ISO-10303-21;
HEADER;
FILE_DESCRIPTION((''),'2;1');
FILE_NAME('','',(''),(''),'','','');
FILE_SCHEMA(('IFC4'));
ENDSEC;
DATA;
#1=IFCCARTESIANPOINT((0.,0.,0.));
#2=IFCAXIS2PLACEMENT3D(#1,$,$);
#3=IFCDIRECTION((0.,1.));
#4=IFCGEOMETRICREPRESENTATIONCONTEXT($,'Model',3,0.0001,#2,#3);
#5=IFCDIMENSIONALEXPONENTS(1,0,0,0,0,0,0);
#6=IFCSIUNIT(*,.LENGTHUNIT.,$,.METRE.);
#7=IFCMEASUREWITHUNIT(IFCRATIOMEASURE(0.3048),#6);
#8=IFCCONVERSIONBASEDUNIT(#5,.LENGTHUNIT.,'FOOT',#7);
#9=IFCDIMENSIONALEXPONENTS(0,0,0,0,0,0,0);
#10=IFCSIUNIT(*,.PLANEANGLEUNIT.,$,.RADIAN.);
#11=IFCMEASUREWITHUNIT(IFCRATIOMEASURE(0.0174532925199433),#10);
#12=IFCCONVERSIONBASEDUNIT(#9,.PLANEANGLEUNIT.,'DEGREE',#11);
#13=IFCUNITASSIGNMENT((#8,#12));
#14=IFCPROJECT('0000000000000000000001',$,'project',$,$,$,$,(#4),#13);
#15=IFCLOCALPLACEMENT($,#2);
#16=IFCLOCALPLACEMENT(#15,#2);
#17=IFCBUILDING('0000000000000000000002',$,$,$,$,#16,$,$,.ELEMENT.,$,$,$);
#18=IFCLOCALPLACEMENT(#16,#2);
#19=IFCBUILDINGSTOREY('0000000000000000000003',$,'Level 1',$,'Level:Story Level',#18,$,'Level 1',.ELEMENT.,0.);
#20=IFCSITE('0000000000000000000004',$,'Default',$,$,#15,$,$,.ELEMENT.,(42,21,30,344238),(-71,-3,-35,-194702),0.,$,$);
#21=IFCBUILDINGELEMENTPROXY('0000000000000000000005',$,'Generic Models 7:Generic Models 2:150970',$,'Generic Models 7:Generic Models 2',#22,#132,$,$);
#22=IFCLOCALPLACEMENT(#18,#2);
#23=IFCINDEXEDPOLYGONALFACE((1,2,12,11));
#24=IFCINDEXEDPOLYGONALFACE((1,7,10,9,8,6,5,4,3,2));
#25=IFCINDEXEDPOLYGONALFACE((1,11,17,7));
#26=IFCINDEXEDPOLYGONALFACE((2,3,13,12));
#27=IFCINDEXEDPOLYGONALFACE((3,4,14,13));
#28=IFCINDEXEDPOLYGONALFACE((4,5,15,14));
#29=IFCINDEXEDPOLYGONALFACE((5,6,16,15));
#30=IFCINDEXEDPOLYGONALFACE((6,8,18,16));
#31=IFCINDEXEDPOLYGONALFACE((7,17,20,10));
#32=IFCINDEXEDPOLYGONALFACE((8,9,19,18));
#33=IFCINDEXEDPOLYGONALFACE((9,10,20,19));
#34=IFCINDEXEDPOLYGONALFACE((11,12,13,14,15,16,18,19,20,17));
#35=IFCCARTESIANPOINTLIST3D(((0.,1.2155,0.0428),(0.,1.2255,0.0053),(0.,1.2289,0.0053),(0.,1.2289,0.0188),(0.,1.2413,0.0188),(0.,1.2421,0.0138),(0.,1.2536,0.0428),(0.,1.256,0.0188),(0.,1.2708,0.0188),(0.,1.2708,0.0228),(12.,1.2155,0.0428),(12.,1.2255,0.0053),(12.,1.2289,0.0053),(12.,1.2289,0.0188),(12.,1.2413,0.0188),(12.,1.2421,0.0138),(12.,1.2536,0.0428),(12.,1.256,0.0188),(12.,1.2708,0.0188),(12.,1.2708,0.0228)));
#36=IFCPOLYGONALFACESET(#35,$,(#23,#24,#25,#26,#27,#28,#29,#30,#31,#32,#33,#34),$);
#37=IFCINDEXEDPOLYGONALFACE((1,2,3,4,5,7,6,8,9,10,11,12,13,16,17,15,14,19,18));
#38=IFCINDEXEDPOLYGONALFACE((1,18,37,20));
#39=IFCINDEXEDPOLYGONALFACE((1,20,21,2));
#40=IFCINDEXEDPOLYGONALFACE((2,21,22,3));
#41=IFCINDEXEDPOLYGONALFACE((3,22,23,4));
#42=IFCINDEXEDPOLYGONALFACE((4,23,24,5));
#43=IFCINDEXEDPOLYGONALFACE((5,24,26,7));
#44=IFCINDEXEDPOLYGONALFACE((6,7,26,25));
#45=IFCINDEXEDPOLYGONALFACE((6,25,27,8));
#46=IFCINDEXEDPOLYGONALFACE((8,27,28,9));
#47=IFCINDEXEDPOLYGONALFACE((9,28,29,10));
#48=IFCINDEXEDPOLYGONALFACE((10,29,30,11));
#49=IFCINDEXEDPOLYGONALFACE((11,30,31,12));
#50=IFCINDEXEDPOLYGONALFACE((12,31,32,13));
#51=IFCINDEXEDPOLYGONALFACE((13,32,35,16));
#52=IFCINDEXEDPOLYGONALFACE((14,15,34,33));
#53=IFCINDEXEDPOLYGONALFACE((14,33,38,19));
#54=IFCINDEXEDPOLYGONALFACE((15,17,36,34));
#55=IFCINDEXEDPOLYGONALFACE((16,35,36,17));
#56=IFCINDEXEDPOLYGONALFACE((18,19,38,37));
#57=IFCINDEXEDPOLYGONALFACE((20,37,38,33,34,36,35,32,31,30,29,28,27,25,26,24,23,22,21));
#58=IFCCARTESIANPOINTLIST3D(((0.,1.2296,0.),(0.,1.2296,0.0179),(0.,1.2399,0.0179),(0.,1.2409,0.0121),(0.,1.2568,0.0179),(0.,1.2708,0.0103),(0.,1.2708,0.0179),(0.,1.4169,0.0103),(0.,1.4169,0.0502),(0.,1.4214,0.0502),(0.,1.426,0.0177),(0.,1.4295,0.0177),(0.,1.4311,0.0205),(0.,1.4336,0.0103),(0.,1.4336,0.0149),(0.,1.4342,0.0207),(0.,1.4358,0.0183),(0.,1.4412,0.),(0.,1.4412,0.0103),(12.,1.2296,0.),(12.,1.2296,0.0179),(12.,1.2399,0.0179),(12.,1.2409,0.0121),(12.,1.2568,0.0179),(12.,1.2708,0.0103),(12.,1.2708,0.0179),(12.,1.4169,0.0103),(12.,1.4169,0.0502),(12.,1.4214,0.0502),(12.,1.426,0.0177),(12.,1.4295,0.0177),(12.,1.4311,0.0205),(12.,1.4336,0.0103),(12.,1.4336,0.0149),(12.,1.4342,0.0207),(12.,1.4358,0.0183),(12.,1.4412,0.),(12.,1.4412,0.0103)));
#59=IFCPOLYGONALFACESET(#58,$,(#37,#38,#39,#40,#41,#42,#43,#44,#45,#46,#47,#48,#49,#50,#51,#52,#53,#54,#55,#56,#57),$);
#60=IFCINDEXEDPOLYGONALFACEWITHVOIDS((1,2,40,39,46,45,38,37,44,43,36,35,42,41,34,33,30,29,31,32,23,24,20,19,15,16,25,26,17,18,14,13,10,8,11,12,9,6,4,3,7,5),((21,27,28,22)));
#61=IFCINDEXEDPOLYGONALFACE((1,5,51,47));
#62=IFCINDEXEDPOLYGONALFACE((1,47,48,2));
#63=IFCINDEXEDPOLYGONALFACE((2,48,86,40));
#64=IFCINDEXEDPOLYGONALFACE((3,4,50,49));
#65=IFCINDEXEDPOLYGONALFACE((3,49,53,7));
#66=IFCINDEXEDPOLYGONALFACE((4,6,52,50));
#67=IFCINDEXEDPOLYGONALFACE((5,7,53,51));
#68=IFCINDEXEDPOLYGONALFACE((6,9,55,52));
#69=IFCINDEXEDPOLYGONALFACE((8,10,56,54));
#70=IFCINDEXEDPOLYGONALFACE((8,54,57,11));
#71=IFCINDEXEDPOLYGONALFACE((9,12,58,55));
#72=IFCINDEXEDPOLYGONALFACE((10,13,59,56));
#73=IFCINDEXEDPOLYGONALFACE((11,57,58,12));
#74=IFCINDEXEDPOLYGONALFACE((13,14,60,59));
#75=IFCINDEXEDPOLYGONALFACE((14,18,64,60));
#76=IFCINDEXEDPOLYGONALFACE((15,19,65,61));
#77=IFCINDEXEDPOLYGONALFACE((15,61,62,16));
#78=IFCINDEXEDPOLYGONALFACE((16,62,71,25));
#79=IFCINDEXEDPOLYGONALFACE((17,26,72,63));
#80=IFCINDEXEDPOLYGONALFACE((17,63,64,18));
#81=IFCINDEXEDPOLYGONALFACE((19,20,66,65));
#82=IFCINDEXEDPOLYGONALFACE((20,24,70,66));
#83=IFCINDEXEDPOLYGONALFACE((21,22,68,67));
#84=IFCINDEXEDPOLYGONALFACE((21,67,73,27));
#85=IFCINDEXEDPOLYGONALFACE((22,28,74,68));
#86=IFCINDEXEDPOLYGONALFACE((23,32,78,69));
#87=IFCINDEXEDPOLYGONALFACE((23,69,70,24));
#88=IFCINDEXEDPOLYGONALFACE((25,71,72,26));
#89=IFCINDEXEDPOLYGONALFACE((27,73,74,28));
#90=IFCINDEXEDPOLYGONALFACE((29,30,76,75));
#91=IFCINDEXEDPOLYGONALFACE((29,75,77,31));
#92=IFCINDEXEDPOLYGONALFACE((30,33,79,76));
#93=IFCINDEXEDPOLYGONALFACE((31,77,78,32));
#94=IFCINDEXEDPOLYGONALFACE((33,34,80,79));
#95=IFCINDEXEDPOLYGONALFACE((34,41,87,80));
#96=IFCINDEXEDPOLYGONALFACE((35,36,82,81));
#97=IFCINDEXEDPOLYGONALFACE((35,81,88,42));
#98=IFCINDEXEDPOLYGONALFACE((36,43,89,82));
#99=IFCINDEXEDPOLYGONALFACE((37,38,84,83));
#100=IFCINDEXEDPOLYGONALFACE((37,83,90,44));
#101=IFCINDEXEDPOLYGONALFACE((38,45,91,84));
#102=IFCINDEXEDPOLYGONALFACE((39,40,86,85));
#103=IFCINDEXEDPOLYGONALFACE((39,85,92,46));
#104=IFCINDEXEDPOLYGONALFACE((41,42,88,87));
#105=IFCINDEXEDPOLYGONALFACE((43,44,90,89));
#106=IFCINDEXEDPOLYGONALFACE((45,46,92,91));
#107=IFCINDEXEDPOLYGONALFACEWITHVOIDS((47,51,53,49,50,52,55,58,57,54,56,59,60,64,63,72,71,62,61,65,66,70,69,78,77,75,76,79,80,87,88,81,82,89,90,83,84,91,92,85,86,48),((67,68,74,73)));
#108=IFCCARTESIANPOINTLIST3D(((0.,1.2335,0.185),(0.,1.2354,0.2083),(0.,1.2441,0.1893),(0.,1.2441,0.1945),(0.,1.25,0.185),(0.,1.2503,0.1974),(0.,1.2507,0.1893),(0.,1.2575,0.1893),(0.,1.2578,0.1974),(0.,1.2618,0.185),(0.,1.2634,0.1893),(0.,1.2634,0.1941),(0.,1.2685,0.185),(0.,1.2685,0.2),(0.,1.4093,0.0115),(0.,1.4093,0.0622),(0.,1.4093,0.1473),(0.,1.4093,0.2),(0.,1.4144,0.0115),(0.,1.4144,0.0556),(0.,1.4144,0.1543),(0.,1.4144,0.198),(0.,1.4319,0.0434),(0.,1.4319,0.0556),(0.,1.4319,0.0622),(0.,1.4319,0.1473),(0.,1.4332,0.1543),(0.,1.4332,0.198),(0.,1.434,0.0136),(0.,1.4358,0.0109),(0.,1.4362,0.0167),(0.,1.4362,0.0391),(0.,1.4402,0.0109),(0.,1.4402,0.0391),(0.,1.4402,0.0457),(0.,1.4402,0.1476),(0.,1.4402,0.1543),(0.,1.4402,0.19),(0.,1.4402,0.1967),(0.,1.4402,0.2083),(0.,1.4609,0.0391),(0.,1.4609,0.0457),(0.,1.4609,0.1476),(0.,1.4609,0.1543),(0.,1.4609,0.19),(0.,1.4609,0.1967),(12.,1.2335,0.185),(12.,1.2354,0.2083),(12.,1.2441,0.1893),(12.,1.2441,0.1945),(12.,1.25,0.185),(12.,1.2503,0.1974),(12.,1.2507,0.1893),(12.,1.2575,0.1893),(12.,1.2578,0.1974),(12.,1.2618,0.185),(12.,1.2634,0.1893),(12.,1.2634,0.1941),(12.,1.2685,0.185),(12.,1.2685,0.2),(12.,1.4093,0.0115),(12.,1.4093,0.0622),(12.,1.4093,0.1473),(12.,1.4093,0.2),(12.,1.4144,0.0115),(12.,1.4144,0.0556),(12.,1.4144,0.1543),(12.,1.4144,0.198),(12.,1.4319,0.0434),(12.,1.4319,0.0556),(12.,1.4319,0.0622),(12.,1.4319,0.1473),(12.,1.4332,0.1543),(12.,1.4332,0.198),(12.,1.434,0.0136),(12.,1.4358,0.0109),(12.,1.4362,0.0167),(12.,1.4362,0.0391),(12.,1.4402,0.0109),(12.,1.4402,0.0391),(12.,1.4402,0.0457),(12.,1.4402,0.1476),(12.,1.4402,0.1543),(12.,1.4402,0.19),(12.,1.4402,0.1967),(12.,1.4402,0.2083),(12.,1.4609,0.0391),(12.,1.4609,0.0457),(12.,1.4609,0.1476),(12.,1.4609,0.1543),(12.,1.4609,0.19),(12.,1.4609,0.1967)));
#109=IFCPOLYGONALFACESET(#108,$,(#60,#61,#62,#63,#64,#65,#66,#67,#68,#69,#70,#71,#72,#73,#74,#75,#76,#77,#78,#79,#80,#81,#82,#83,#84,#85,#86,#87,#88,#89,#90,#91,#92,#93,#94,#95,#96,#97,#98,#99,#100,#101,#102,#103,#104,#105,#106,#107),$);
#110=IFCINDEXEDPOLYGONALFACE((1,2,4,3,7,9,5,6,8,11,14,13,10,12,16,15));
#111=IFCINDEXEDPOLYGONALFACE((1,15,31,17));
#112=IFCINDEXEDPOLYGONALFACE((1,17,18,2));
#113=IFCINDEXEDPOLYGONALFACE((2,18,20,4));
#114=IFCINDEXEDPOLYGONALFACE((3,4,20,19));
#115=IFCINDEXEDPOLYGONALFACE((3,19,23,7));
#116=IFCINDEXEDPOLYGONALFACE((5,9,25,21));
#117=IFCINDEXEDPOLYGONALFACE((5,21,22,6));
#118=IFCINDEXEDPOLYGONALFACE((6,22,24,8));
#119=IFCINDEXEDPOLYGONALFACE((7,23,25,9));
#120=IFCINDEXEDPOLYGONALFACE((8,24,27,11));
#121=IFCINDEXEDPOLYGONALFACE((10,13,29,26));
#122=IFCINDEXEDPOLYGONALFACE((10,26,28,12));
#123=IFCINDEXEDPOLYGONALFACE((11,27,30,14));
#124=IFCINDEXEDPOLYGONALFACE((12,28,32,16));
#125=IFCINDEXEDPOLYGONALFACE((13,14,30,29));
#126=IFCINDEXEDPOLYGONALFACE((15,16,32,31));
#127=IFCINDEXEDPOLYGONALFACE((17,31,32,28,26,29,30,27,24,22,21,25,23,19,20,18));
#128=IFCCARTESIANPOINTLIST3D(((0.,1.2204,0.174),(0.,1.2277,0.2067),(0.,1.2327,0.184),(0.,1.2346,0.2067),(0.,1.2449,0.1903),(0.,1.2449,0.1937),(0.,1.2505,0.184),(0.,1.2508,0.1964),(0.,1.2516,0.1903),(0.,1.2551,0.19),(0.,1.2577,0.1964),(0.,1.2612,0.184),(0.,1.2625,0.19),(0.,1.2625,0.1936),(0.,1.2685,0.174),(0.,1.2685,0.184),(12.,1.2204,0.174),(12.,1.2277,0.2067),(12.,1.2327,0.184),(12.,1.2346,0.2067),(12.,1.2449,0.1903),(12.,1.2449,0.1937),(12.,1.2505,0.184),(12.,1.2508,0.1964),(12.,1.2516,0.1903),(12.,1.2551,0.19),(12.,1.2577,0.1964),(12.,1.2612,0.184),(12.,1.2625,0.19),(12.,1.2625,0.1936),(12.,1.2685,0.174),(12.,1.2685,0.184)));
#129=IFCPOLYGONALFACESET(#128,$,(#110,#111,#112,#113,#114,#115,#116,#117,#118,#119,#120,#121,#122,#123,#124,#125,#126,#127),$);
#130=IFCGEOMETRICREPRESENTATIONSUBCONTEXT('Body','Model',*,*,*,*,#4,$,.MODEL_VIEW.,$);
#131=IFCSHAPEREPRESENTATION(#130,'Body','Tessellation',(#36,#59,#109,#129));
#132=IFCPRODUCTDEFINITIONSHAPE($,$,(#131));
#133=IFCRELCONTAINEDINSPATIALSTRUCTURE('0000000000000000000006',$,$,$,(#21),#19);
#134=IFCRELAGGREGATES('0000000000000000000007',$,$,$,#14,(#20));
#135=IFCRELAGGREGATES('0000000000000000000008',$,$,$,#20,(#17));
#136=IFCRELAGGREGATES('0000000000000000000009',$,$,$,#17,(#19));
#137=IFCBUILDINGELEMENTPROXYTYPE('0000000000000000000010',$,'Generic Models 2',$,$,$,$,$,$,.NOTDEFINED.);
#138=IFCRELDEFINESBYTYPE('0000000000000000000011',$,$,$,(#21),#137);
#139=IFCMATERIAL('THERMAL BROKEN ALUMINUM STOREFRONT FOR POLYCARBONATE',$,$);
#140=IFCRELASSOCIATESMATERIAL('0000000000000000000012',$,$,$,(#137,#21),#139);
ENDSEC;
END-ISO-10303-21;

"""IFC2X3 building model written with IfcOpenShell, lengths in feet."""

from ifc_helpers import new_model, entity, si_unit, converted_unit, direction, frame, origin, place, context, subcontext, project, spatial, polyline, outline, extrude, source, transform, mapped, material, type_object, type_shapes, element, save


model = new_model("IFC2X3")

# Units and contexts
model_context = context("Model", 3, precision=0.0001, world=origin(), true_north=direction((0.0, 1.0)))
body_context = subcontext(model_context, "Body", "Model", "MODEL_VIEW")
ifc_project = project(units=[converted_unit("LENGTHUNIT", "FOOT", entity("IfcRatioMeasure", 0.3048), si_unit("LENGTHUNIT", "METRE"), dimensions=[1, 0, 0, 0, 0, 0, 0]), converted_unit("PLANEANGLEUNIT", "DEGREE", entity("IfcRatioMeasure", 0.0174532925199433), si_unit("PLANEANGLEUNIT", "RADIAN"), dimensions=[0, 0, 0, 0, 0, 0, 0])], contexts=[model_context])

# Site, building, storey
site_placement = place(None, origin())
site = spatial("IfcSite", under=ifc_project, at=site_placement, Name="Default", CompositionType="ELEMENT", RefLatitude=(42, 21, 30, 344238), RefLongitude=(-71, -3, -35, -194702), RefElevation=0.0)
building_placement = place(site_placement, origin())
building = spatial("IfcBuilding", under=site, at=building_placement, CompositionType="ELEMENT")
storey_placement = place(building_placement, origin())
storey = spatial("IfcBuildingStorey", under=building, at=storey_placement, Name="Level 1", ObjectType="Level:Story Level", LongName="Level 1", CompositionType="ELEMENT", Elevation=0.0)

# Building element proxy
ifc_material = material(Name="THERMAL BROKEN ALUMINUM STOREFRONT FOR POLYCARBONATE")
building_element_proxy_type_1 = type_object("IfcBuildingElementProxyType", Name="Generic Models 2", PredefinedType="NOTDEFINED", material=ifc_material)
shared_shape_1 = source(origin(), body_context, "Body", "SweptSolid", [
    extrude(outline(polyline([(-0.0178, -0.0155), (-0.0144, -0.0155), (-0.0144, -0.002), (-0.0021, -0.002), (-0.0012, -0.007), (0.0126, -0.002), (0.0275, -0.002), (0.0275, 0.002), (0.0102, 0.022), (-0.0278, 0.022), (-0.0178, -0.0155)])), frame((-15.0475, -0.4208, -0.4887), z_axis=(1.0, 0.0, 0.0), x_axis=(0.0, 1.0, 0.0)), (0.0, 0.0, 1.0), 12.0),
    extrude(outline(polyline([(-0.0355, -0.058), (-0.0371, -0.0606), (-0.0358, -0.0632), (-0.0318, -0.063), (-0.0278, -0.0652), (-0.0315, -0.0718), (-0.0224, -0.0768), (0.0802, 0.1083), (0.0645, 0.1169), (0.0595, 0.1079), (0.0642, 0.1042), (0.0513, 0.0931), (0.0445, 0.0809), (0.0512, 0.0772), (-0.0197, -0.0506), (-0.0545, -0.0312), (-0.0567, -0.0352), (-0.0306, -0.055), (-0.0322, -0.058), (-0.0355, -0.058)])), frame((-15.0475, -0.301, -0.4919), z_axis=(-1.0, 0.0, 0.0), x_axis=(0.0, -0.484974, -0.874529)), (0.0, 0.0, -1.0), 12.0),
    extrude(outline(polyline([(-0.107, -0.073), (-0.107, -0.058), (-0.1137, -0.058), (-0.118, -0.0623), (-0.1121, -0.0623), (-0.1121, -0.0672), (-0.1177, -0.0704), (-0.1252, -0.0704), (-0.1315, -0.0675), (-0.1315, -0.0623), (-0.1248, -0.0623), (-0.1255, -0.058), (-0.142, -0.058), (-0.1401, -0.0814), (0.0647, -0.0814), (0.0647, -0.0697), (0.0853, -0.0697), (0.0853, -0.0631), (0.0647, -0.0631), (0.0647, -0.0273), (0.0853, -0.0273), (0.0853, -0.0207), (0.0647, -0.0207), (0.0647, 0.0812), (0.0853, 0.0812), (0.0853, 0.0878), (0.0647, 0.0878), (0.0647, 0.1161), (0.0603, 0.1161), (0.0585, 0.1133), (0.0606, 0.1102), (0.0606, 0.0878), (0.0564, 0.0836), (0.0564, 0.0713), (0.0389, 0.0713), (0.0389, 0.1155), (0.0338, 0.1155), (0.0338, 0.0647), (0.0564, 0.0647), (0.0564, -0.0203), (0.0338, -0.0203), (0.0338, -0.073), (-0.107, -0.073)]), holes=[polyline([(0.0577, -0.0711), (0.0389, -0.0711), (0.0389, -0.0273), (0.0577, -0.0273), (0.0577, -0.0711)])]), frame((-15.0475, -0.2887, -0.3825), z_axis=(-1.0, 0.0, 0.0), x_axis=(0.0, 1.0, 0.0)), (0.0, 0.0, -1.0), 12.0),
    extrude(outline(polyline([(-0.0292, -0.0159), (0.0189, -0.0159), (0.0189, -0.0059), (0.0115, -0.0059), (0.0055, 0.0001), (0.0129, 0.0001), (0.0129, 0.0037), (0.008, 0.0065), (0.0012, 0.0065), (-0.0047, 0.0038), (-0.0047, 0.0004), (0.002, 0.0004), (0.0009, -0.0059), (-0.017, -0.0059), (-0.015, 0.0168), (-0.0219, 0.0168), (-0.0292, -0.0159)])), frame((-15.0475, -0.4146, -0.3196), z_axis=(1.0, 0.0, 0.0), x_axis=(0.0, 1.0, 0.0)), (0.0, 0.0, 1.0), 12.0),
])
type_shapes(building_element_proxy_type_1, [shared_shape_1])
proxy_1_placement = place(storey_placement, frame((15.0475, 1.6642, 0.5095)))
element("IfcBuildingElementProxy", 1, at=proxy_1_placement, inside=storey, type_object=building_element_proxy_type_1, material=ifc_material, Name="Generic Models 7:Generic Models 2:150970", ObjectType="Generic Models 7:Generic Models 2", context=body_context, shape_type="MappedRepresentation", body=[
    mapped(shared_shape_1, transform((0.0, 0.0, 0.0), scale=1.0)),
])

save(model, "model.ifc")
